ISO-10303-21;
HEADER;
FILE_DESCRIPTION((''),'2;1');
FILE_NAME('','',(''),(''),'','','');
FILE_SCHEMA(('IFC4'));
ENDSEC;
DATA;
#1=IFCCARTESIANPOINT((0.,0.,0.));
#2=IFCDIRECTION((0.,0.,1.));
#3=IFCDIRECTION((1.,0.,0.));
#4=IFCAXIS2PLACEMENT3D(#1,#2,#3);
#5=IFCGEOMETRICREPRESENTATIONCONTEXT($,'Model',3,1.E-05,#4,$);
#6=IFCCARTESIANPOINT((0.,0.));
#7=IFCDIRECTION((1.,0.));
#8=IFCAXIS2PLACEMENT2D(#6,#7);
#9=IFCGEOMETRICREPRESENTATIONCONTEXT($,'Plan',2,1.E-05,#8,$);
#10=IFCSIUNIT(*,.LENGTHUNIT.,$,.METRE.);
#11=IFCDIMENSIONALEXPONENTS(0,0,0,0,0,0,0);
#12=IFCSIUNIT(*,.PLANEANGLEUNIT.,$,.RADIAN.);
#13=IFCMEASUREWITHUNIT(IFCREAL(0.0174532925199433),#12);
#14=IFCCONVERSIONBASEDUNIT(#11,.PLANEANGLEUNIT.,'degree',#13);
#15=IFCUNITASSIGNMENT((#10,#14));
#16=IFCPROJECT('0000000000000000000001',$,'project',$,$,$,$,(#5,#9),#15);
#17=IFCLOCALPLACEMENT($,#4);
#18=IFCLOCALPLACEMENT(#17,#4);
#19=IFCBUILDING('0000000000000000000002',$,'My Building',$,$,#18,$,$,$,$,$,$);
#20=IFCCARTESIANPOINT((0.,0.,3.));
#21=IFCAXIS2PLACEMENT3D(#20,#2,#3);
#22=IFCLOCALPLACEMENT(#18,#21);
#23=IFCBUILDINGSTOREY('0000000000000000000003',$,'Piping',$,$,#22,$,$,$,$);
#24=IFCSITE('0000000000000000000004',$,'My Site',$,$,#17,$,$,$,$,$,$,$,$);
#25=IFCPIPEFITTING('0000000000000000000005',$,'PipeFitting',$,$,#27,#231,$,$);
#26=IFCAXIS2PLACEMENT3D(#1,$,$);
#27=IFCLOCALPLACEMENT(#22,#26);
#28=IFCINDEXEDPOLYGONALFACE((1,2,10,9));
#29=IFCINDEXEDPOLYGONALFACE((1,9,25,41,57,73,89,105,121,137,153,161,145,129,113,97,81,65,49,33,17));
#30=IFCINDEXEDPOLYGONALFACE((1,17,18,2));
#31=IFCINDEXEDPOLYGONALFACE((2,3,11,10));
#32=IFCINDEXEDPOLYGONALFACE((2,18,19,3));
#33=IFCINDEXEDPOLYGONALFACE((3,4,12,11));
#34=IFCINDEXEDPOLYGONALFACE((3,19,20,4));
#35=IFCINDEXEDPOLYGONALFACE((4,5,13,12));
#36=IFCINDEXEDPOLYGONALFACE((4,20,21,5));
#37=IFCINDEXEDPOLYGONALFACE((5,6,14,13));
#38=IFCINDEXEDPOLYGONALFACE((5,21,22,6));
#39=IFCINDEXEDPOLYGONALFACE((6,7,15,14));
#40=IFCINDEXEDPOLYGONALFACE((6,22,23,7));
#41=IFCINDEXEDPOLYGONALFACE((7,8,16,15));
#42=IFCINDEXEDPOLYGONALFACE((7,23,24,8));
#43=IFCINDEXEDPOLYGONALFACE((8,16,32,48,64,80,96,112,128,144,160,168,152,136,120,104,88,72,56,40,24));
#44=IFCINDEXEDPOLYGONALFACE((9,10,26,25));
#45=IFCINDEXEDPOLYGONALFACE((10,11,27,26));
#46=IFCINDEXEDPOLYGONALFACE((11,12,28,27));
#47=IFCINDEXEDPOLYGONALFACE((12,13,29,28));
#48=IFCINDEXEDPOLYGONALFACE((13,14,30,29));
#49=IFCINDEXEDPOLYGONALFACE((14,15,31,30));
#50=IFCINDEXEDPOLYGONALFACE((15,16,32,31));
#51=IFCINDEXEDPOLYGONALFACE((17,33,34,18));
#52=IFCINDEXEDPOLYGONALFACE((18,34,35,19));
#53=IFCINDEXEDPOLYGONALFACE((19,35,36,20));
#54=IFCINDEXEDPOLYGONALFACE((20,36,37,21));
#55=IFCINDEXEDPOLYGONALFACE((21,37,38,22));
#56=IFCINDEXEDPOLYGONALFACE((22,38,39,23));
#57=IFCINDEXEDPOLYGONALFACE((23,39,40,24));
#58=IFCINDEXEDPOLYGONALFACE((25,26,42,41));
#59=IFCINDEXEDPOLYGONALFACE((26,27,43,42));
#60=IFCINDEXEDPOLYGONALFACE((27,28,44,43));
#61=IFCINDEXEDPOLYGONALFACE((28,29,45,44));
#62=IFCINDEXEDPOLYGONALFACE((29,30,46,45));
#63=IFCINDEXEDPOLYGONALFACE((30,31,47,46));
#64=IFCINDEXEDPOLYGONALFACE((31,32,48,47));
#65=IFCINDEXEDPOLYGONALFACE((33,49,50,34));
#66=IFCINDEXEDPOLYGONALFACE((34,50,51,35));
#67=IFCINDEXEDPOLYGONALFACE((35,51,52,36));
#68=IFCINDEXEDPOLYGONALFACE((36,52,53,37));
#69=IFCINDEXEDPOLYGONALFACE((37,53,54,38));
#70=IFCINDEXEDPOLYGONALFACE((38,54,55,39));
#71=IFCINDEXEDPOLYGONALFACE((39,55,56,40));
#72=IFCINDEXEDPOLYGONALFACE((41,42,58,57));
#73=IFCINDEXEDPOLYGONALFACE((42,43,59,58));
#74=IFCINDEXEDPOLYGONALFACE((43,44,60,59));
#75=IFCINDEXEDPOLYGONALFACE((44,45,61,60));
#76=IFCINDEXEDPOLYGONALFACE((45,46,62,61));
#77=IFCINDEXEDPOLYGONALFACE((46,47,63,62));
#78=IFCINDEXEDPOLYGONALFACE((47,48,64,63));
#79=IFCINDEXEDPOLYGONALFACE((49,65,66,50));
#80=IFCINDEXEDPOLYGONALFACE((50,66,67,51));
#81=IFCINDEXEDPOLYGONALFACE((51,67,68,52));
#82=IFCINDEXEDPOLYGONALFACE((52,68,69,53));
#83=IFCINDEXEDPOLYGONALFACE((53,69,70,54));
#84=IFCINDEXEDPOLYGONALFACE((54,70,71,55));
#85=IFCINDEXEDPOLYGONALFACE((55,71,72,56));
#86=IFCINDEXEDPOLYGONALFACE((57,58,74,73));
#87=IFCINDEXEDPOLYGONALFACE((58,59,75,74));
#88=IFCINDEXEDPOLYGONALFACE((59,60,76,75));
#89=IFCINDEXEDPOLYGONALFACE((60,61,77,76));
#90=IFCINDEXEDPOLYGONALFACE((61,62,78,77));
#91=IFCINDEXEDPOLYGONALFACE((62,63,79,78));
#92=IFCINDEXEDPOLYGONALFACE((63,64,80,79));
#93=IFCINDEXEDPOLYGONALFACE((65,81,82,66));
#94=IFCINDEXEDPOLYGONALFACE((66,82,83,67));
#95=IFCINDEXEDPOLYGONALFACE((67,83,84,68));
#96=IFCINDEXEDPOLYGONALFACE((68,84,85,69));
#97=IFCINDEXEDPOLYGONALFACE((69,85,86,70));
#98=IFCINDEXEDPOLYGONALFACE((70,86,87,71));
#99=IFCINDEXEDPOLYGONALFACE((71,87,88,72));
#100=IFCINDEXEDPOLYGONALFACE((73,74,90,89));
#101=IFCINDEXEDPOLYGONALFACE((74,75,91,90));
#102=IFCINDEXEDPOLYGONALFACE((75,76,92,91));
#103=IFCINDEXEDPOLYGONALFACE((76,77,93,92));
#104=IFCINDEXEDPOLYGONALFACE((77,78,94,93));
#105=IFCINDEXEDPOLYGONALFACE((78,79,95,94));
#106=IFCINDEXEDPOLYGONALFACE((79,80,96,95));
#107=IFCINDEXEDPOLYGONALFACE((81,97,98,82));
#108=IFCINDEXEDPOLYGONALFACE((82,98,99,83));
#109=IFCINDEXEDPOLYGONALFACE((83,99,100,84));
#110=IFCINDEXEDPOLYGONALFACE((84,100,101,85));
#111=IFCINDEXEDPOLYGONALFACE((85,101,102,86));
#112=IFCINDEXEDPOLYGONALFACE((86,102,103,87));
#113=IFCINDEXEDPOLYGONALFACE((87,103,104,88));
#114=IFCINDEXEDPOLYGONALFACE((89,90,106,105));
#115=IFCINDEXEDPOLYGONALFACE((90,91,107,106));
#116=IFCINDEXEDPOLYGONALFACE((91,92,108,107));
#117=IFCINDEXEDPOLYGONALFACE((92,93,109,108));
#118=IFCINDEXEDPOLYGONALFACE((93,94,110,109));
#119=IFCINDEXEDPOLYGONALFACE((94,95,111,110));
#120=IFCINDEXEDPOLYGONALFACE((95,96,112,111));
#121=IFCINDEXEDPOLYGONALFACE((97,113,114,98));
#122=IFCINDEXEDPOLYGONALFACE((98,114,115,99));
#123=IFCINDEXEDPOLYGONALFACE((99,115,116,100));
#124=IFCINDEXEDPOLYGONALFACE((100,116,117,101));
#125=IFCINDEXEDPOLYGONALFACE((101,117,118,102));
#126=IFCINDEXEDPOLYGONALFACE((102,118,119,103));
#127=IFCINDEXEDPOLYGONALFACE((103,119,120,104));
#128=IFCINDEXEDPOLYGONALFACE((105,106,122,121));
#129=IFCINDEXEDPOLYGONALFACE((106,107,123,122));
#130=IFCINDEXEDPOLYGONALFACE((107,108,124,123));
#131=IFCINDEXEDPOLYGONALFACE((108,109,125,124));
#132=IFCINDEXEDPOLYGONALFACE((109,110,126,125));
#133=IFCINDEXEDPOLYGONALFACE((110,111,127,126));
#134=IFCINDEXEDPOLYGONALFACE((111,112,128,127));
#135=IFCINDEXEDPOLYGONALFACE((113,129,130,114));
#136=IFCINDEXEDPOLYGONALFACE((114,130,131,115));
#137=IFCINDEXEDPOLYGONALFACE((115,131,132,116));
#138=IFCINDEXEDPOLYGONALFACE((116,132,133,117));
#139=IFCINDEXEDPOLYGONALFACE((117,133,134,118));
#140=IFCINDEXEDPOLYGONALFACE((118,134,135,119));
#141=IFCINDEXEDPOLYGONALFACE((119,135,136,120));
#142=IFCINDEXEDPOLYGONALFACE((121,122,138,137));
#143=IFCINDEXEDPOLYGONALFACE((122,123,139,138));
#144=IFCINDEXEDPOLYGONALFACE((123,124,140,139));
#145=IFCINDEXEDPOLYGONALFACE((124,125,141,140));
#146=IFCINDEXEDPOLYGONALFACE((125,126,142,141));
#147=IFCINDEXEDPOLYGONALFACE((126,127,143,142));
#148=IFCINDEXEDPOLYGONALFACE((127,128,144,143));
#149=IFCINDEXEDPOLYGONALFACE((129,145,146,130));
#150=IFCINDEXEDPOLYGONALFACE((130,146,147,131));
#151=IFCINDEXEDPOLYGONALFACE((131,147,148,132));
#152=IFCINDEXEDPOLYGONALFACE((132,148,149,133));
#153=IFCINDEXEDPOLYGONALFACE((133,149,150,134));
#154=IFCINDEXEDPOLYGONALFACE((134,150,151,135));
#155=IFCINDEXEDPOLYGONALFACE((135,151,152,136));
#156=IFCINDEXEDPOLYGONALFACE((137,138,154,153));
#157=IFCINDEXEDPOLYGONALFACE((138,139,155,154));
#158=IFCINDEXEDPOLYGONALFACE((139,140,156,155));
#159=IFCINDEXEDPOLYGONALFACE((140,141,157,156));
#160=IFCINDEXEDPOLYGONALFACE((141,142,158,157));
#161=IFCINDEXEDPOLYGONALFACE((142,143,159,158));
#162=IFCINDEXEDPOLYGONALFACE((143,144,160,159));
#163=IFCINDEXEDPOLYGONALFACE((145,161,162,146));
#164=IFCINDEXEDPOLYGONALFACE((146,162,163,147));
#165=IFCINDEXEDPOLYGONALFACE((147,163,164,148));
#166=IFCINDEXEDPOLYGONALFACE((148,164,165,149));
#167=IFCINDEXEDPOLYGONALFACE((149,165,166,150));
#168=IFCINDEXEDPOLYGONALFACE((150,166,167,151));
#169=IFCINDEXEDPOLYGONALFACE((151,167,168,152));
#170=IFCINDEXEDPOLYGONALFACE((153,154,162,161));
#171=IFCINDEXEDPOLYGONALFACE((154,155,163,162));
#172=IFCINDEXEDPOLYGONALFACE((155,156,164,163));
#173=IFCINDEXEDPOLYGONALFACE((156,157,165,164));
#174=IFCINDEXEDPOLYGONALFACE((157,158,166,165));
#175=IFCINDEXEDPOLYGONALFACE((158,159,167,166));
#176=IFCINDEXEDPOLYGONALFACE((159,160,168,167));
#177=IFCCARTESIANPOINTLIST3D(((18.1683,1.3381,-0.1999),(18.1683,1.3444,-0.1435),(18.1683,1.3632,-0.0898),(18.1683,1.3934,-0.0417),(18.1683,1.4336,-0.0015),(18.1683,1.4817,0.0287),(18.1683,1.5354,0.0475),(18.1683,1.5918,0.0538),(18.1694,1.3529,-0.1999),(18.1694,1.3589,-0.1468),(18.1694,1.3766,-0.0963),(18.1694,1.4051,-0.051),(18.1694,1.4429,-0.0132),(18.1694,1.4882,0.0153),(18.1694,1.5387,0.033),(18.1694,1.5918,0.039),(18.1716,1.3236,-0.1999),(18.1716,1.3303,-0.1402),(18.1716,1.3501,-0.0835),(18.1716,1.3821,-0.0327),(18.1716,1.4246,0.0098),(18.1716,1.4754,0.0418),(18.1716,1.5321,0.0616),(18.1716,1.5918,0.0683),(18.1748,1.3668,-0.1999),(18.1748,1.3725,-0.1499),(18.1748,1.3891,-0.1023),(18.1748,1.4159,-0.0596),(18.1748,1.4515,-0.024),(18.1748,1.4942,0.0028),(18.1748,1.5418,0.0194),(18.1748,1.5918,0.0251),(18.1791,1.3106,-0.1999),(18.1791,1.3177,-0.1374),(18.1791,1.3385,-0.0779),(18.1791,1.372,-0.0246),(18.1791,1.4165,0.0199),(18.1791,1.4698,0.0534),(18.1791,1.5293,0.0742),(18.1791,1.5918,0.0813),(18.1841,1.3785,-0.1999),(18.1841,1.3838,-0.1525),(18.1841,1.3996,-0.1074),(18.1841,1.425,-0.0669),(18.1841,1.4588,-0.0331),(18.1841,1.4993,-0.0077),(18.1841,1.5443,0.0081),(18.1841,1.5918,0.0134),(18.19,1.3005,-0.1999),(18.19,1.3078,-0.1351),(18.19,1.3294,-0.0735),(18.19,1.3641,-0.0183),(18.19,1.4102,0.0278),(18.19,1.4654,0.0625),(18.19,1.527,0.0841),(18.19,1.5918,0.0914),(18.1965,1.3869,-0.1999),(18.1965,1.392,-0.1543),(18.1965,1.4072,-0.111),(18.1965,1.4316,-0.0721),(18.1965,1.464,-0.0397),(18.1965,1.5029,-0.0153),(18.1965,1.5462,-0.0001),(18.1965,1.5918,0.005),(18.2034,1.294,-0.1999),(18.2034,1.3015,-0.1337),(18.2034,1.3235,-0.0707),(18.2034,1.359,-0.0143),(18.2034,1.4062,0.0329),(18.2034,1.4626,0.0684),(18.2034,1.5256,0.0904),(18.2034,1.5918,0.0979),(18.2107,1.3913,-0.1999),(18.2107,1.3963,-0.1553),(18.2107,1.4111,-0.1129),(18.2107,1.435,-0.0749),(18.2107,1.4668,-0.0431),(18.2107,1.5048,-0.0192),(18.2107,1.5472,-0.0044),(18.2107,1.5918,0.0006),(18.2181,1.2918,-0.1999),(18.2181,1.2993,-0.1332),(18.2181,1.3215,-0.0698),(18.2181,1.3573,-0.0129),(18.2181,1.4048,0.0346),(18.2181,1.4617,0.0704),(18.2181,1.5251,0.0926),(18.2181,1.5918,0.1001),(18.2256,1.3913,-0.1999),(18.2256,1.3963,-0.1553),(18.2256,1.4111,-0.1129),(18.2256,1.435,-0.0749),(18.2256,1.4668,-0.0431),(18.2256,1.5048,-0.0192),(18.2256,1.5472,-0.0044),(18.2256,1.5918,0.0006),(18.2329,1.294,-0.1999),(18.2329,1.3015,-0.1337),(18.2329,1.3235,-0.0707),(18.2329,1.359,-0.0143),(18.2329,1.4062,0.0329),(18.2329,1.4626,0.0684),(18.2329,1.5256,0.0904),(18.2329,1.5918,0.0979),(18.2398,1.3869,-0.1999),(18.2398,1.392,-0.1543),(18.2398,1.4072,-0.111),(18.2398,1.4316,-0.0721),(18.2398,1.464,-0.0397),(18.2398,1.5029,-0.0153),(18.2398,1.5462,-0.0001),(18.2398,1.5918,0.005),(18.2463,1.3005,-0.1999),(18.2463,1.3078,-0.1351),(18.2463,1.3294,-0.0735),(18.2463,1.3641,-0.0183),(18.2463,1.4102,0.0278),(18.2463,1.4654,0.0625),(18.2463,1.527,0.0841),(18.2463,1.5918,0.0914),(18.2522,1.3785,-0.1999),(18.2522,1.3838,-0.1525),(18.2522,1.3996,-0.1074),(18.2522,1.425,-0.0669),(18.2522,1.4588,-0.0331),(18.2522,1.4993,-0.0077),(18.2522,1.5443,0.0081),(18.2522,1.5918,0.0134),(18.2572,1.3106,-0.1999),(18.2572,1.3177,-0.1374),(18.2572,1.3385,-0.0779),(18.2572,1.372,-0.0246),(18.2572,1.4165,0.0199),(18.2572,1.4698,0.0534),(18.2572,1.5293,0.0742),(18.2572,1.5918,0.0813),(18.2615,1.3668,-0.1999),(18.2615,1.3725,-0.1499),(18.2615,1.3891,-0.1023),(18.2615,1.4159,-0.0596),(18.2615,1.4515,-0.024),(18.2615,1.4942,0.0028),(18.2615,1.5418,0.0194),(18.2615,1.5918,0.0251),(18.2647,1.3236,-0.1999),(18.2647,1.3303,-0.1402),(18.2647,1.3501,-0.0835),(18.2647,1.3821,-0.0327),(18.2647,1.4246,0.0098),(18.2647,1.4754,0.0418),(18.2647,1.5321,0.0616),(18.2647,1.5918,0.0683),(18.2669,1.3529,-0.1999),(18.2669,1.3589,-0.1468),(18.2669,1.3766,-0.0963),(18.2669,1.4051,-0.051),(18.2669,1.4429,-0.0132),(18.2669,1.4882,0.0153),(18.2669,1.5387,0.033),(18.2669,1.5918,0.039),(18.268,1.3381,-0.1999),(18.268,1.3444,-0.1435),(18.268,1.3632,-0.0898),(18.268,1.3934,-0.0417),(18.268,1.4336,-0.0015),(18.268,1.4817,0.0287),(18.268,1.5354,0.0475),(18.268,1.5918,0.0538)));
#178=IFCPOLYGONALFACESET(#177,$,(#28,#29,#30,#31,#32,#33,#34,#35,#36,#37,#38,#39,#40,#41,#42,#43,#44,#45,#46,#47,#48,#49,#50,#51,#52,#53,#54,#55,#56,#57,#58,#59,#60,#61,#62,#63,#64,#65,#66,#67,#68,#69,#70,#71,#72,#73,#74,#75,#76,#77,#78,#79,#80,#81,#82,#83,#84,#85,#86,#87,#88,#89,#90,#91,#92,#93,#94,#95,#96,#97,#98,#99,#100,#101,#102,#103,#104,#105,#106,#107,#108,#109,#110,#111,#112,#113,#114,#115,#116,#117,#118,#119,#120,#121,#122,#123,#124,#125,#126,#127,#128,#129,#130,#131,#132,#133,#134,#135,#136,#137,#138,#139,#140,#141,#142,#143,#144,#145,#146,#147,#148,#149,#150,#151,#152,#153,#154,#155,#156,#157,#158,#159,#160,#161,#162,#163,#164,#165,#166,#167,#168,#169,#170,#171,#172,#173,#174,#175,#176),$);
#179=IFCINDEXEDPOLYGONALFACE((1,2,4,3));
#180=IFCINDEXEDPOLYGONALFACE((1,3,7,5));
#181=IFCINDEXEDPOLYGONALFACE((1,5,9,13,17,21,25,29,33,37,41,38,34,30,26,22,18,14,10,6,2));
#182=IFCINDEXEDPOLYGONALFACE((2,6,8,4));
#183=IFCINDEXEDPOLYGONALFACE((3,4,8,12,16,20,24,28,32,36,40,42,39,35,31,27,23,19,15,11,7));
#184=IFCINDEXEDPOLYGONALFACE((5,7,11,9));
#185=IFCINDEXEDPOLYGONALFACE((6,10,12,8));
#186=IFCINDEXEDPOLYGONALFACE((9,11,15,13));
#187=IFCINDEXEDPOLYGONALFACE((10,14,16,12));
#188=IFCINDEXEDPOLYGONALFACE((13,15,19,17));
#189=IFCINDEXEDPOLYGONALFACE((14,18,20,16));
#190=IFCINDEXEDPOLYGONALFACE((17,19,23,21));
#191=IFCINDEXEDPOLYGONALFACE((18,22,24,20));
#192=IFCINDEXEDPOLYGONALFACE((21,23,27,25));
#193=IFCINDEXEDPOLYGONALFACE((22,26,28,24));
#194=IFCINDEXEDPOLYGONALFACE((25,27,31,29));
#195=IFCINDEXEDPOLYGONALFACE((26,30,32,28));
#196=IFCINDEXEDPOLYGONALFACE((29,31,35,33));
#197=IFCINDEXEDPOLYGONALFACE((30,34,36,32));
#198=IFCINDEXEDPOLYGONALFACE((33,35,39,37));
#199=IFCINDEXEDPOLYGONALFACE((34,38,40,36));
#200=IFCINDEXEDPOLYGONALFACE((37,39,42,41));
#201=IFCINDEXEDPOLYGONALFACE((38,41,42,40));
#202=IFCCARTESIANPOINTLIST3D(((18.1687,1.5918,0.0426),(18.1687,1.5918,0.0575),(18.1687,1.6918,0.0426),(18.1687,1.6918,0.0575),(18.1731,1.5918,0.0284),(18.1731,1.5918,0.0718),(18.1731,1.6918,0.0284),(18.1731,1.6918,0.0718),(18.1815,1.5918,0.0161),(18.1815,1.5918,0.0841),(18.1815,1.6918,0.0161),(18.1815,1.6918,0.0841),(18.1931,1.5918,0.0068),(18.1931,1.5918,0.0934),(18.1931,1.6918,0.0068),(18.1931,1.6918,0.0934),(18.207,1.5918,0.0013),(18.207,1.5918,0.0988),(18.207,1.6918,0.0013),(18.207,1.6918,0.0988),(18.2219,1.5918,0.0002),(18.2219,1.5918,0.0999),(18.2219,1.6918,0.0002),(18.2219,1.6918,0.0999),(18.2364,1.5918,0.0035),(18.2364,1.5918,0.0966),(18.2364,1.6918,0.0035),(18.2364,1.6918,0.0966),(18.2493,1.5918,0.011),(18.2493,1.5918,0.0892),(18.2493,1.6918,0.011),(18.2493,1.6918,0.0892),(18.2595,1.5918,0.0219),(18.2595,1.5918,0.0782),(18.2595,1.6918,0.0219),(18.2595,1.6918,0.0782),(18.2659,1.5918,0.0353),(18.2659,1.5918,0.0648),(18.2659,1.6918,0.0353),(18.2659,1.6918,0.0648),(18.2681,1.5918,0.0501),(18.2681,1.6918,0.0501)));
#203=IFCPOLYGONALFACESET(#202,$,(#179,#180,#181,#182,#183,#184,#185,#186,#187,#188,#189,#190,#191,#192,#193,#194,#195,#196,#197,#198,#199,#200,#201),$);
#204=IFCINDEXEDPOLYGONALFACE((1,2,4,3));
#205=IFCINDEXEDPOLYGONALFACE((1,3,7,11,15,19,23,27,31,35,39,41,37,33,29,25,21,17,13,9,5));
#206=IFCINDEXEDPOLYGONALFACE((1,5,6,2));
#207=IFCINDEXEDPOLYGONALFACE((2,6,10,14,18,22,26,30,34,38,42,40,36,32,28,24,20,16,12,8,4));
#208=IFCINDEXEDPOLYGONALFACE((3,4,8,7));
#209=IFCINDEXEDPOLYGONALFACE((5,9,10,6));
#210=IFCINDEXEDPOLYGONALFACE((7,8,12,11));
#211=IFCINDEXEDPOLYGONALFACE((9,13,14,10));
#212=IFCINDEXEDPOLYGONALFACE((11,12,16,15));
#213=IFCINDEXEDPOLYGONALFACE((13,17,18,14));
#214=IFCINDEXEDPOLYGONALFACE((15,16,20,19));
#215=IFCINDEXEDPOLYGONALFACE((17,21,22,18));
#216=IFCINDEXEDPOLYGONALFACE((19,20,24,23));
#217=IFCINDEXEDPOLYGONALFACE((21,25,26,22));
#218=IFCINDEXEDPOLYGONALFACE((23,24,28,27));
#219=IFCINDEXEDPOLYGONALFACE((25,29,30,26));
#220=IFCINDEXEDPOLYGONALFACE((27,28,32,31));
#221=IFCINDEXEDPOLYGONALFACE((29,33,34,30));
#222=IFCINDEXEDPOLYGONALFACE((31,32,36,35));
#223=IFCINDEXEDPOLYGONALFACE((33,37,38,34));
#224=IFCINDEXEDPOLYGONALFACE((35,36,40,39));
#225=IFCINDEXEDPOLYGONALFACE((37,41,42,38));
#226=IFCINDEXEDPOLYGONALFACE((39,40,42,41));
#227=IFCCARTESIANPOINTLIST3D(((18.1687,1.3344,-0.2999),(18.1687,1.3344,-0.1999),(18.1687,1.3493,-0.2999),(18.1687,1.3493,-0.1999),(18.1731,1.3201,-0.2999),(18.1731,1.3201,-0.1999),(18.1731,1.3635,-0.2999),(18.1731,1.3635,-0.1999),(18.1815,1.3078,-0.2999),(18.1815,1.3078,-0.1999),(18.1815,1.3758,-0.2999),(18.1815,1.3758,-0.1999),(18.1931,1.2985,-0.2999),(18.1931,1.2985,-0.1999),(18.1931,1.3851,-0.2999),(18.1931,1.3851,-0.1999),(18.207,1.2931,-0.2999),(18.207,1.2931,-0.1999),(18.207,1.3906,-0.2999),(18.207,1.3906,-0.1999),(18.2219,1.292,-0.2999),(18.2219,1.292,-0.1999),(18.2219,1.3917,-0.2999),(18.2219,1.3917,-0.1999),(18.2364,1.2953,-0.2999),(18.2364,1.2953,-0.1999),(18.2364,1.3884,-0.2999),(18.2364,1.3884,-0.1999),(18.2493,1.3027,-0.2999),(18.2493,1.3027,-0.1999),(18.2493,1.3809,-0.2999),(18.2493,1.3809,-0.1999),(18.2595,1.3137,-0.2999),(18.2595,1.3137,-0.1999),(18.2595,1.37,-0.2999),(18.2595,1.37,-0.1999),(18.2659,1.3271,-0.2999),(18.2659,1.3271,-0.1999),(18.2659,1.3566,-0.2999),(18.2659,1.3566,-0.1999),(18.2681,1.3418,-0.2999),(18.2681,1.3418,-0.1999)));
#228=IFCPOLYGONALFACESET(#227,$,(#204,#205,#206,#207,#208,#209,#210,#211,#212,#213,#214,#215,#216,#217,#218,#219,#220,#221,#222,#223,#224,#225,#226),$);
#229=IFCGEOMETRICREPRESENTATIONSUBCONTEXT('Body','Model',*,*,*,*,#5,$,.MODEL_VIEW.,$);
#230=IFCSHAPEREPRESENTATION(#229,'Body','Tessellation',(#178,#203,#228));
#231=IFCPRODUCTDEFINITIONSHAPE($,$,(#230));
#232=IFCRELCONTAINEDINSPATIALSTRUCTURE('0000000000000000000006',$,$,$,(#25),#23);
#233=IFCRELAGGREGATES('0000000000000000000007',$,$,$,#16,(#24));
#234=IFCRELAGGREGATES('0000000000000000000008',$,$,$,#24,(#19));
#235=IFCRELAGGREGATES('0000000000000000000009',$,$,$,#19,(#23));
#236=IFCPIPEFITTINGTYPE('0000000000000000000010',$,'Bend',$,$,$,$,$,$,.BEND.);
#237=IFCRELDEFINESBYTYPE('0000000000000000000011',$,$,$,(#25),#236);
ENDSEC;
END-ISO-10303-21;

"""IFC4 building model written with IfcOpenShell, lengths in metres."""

from ifc_helpers import new_model, entity, si_unit, converted_unit, frame, origin_with_axes, origin_2d_with_axis, place, context, subcontext, project, spatial, circle, extrude, source, transform, mapped, type_object, type_shapes, element, save


model = new_model("IFC4")

# Units and contexts
model_context = context("Model", 3, precision=1e-05, world=origin_with_axes())
plan_context = context("Plan", 2, precision=1e-05, world=origin_2d_with_axis())
body_context = subcontext(model_context, "Body", "Model", "MODEL_VIEW")
ifc_project = project(units=[si_unit("LENGTHUNIT", "METRE"), converted_unit("PLANEANGLEUNIT", "degree", entity("IfcReal", 0.0174532925199433), si_unit("PLANEANGLEUNIT", "RADIAN"), dimensions=[0, 0, 0, 0, 0, 0, 0])], contexts=[model_context, plan_context])

# Site, building, storey
site_placement = place(None, origin_with_axes())
site = spatial("IfcSite", under=ifc_project, at=site_placement, Name="My Site")
building_placement = place(site_placement, origin_with_axes())
building = spatial("IfcBuilding", under=site, at=building_placement, Name="My Building")
storey_placement = place(building_placement, frame((0.0, 0.0, 3.0), z_axis=(0.0, 0.0, 1.0), x_axis=(1.0, 0.0, 0.0)))
storey = spatial("IfcBuildingStorey", under=building, at=storey_placement, Name="Piping")

# Pipe fitting
pipe_fitting_type_1 = type_object("IfcPipeFittingType", Name="Bend", PredefinedType="BEND")
shared_shape = source(origin_with_axes(), body_context, "Body", "SolidModel", [
    entity("IfcSweptDiskSolid", entity("IfcIndexedPolyCurve", entity("IfcCartesianPointList3D", [[0.0, 0.0, 0.1], [0.0, -0.0732, 0.2768], [0.0, -0.25, 0.35]]), [entity("IfcArcIndex", [1, 2, 3])]), 0.05),
    extrude(circle(Radius=0.05), origin_with_axes(), (0.0, 0.0, 1.0), 0.1),
    extrude(circle(Radius=0.05), frame((0.0, -0.25, 0.35), z_axis=(0.0, -1.0, -0.000003), x_axis=(1.0, 0.0, 0.0)), (0.0, 0.0, 1.0), 0.1),
])
type_shapes(pipe_fitting_type_1, [shared_shape])
for number, where, z_axis, x_axis, name in (
    (1, (18.2181, 1.6918, 0.0501), (0.0, -1.0, 0.0), (1.0, 0.0, 0.0), "PipeFitting"),
):
    element("IfcPipeFitting", number, at=place(storey_placement, frame(where, z_axis=z_axis, x_axis=x_axis)), inside=storey, type_object=pipe_fitting_type_1, Name=name, context=body_context, shape_type="MappedRepresentation", body=[
        mapped(shared_shape, transform((0.0, 0.0, 0.0), x_axis=(1.0, 0.0, 0.0), y_axis=(0.0, 1.0, 0.0), z_axis=(0.0, 0.0, 1.0), scale=1.0)),
    ])

save(model, "model.ifc")
